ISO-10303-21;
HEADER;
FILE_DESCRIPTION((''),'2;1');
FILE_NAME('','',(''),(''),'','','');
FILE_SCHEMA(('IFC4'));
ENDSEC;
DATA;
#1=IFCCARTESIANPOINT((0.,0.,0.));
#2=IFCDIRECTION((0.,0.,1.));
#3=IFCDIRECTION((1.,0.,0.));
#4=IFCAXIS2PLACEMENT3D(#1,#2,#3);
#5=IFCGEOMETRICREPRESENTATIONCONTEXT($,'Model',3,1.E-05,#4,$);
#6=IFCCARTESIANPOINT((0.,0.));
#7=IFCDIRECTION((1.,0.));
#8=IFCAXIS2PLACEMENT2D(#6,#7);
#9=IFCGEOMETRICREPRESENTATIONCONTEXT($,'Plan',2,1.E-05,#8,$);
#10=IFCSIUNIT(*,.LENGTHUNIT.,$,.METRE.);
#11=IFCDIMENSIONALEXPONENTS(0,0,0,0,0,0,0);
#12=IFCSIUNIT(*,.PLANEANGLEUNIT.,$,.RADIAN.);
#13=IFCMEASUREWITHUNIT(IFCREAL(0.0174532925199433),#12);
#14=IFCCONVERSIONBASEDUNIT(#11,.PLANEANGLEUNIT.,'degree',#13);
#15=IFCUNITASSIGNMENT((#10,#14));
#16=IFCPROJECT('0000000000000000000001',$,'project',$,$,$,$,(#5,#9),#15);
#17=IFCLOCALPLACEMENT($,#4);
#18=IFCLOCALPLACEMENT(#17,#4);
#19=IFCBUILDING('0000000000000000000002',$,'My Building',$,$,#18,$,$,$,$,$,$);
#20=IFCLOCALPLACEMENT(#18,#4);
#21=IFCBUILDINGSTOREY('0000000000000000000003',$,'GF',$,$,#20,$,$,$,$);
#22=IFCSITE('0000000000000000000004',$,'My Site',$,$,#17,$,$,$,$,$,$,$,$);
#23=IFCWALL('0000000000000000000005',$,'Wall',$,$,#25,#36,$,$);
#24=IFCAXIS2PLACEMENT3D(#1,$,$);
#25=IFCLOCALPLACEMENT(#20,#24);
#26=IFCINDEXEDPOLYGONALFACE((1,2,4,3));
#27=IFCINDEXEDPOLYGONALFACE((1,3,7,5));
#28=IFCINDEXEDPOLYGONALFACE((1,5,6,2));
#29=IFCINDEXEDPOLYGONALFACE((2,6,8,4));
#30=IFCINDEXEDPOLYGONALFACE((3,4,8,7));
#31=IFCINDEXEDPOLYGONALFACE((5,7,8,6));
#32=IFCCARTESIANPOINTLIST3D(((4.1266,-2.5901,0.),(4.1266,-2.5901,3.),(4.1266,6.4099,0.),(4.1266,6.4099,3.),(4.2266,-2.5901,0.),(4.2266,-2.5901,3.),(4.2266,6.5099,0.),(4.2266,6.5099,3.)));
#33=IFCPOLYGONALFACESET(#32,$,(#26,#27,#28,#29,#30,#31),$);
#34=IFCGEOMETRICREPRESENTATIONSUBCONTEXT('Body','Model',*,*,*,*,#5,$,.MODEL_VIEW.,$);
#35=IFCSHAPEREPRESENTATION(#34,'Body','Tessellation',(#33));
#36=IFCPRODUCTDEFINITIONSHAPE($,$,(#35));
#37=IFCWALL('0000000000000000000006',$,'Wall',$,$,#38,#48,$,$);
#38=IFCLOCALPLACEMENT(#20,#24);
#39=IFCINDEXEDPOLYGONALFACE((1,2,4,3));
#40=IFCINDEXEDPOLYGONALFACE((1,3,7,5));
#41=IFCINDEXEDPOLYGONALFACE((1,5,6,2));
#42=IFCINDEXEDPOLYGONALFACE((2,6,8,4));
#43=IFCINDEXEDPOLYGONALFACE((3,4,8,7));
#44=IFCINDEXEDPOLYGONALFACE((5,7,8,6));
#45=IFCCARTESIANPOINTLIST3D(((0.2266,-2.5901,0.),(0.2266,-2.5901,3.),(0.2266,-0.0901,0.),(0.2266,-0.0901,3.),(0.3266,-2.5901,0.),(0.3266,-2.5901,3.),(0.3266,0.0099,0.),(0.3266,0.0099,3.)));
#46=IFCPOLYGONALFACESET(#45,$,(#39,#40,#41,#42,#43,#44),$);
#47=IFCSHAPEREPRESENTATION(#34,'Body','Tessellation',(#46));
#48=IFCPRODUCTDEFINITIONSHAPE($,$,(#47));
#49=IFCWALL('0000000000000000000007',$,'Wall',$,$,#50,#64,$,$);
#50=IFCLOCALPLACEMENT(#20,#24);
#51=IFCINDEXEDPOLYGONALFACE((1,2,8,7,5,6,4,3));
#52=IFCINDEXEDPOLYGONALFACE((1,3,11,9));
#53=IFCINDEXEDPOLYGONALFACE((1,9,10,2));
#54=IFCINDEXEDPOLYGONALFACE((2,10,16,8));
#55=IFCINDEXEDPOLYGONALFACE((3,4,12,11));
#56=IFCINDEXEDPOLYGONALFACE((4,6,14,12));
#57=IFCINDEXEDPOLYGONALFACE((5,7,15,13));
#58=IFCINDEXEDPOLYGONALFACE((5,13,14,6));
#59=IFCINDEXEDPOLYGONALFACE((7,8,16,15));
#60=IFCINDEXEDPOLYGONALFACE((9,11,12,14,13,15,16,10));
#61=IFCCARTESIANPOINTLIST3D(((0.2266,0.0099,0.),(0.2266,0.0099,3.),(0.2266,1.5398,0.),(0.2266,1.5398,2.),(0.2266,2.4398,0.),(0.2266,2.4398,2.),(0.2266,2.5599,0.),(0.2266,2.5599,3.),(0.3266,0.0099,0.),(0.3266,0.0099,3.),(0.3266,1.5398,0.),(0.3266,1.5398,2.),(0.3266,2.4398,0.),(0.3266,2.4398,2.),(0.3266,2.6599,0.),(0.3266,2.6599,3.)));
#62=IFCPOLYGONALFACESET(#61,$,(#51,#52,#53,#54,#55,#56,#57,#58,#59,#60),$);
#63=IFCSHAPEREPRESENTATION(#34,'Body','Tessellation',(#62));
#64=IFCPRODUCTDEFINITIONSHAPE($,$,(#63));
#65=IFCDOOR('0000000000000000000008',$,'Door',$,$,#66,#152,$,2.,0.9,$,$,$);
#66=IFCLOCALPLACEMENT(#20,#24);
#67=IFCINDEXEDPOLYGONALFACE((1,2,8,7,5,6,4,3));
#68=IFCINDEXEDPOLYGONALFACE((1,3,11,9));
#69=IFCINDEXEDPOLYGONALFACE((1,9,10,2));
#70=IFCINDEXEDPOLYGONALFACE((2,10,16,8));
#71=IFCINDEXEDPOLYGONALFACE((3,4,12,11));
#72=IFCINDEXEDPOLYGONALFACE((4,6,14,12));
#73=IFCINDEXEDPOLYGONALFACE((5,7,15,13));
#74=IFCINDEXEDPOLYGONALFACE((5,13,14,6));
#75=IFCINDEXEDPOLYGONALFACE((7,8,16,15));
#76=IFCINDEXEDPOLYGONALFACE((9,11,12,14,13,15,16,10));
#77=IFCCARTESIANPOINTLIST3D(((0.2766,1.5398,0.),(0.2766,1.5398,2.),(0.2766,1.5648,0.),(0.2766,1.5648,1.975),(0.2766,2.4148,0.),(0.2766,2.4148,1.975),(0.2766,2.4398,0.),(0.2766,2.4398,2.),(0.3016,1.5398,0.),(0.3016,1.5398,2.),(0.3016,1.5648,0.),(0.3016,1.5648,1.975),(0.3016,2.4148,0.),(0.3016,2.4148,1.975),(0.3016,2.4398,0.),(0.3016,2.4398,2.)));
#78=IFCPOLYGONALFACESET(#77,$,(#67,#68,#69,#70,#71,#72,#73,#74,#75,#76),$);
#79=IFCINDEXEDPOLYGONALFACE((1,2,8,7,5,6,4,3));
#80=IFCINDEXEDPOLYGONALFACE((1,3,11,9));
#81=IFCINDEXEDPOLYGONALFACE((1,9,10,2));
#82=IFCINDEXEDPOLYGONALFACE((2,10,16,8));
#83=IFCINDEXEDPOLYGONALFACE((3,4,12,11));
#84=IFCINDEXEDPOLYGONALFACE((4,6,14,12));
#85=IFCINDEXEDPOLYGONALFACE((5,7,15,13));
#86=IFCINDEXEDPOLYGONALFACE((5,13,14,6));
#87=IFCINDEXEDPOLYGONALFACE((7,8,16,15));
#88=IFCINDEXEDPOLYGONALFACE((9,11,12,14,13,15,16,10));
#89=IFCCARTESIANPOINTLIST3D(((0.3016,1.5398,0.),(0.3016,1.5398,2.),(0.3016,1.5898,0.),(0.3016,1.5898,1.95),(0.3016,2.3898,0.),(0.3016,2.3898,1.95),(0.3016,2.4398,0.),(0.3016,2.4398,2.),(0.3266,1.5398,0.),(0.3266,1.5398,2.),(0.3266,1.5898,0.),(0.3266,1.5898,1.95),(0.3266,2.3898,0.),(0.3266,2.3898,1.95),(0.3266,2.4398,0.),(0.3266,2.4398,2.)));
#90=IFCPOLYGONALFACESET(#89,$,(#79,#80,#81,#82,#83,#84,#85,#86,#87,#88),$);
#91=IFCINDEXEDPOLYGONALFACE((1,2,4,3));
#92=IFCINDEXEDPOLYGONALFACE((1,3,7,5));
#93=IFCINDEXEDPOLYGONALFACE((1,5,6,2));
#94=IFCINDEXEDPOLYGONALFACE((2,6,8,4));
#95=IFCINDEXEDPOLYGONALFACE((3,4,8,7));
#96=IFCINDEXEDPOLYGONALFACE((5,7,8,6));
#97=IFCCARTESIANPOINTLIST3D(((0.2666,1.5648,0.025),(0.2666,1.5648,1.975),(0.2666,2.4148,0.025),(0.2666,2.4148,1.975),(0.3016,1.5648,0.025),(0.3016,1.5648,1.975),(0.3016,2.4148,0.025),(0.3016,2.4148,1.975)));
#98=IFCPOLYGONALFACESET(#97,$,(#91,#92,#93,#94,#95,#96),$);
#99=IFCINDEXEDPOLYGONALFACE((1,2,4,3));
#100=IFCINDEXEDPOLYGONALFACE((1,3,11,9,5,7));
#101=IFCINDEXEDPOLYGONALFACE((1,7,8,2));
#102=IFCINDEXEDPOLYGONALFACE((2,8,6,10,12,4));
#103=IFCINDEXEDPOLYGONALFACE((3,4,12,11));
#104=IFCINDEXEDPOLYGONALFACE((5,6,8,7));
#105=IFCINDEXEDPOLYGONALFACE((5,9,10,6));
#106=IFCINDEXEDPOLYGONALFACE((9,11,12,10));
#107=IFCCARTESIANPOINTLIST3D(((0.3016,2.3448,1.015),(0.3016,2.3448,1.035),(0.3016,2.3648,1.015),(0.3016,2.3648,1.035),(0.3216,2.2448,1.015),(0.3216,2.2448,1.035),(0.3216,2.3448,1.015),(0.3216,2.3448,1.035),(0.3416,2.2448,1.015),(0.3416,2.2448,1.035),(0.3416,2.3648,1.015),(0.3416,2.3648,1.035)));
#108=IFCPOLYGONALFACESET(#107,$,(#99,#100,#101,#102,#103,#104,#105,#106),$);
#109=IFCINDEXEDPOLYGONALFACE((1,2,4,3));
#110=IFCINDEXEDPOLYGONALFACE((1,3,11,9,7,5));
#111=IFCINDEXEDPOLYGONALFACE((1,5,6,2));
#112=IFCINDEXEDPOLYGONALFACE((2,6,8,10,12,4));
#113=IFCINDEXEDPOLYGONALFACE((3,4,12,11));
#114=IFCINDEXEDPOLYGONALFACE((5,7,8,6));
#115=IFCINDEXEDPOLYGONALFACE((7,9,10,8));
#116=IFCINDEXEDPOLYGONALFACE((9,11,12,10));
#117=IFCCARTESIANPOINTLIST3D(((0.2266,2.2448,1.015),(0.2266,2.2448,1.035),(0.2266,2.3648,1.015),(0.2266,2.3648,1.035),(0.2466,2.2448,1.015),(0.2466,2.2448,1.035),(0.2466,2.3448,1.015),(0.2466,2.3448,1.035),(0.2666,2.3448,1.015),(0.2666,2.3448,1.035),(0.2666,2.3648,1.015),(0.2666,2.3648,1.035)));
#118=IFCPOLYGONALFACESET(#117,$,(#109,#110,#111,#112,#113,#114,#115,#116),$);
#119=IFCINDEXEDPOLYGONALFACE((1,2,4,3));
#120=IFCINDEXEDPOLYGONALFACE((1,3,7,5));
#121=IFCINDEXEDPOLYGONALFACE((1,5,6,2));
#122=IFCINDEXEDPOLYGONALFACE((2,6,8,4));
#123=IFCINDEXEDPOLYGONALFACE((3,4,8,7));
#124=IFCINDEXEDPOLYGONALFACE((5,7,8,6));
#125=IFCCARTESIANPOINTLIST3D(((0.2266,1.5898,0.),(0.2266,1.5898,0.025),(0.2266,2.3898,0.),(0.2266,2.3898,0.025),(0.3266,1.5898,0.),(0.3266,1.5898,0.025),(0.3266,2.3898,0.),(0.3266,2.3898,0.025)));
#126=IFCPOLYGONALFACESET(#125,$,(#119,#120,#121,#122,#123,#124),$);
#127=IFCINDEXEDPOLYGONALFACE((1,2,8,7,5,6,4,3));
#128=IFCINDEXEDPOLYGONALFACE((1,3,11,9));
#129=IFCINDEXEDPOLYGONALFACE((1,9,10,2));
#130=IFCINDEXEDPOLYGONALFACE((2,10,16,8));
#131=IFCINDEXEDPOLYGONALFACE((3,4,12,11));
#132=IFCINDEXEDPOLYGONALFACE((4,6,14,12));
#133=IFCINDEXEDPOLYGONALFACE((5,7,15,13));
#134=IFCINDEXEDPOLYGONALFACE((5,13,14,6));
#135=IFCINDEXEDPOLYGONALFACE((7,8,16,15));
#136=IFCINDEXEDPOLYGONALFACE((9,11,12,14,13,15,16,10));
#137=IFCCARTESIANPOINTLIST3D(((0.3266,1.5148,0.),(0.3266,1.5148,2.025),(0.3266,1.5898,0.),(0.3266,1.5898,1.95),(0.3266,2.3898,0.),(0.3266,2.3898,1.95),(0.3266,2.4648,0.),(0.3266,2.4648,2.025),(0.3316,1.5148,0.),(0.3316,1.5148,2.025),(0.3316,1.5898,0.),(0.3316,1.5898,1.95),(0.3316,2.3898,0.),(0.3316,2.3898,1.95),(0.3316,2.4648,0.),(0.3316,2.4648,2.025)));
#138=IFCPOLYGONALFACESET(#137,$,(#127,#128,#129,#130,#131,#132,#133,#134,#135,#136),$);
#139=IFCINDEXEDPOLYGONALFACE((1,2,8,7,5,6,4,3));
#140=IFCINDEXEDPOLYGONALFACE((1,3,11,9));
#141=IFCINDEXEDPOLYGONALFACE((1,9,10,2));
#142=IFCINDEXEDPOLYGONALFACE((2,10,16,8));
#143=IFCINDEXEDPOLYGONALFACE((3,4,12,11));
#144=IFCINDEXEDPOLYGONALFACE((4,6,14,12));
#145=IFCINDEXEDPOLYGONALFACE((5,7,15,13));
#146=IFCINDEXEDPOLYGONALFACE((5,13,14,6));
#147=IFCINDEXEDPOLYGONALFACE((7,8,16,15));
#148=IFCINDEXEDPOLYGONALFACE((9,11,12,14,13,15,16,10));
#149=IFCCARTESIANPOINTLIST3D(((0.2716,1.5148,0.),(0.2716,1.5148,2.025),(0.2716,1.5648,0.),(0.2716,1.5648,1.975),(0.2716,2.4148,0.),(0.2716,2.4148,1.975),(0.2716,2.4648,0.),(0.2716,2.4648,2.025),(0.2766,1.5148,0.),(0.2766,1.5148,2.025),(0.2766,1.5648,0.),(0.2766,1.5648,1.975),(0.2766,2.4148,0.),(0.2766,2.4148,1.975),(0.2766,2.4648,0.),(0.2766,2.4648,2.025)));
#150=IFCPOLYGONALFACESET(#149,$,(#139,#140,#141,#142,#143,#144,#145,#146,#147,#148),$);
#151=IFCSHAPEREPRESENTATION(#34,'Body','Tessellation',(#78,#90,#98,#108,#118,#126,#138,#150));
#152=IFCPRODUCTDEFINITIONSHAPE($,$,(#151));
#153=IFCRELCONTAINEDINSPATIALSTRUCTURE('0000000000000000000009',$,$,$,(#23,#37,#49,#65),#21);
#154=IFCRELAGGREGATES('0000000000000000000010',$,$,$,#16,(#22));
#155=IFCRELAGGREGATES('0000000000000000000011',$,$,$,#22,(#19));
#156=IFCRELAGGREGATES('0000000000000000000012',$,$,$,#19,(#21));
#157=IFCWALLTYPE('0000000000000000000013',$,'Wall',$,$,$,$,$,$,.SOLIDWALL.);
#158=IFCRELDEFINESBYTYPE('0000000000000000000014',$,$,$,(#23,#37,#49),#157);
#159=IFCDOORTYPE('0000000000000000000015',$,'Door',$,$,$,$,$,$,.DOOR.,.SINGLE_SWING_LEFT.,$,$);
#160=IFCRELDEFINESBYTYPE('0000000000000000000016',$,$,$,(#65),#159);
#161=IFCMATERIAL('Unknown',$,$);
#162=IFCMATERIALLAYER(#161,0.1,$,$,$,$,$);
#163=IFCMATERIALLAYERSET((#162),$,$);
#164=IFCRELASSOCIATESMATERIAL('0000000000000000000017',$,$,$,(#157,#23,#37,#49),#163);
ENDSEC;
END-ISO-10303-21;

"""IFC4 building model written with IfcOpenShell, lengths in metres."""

from ifc_helpers import new_model, entity, si_unit, converted_unit, frame, origin_with_axes, origin_2d_with_axis, place, context, subcontext, project, spatial, line, indexed_curve, outline, extrude, shape, source, transform, mapped, material, layer, layer_set, layer_usage, type_object, type_shapes, element, fill, save


model = new_model("IFC4")

# Units and contexts
model_context = context("Model", 3, precision=1e-05, world=origin_with_axes())
plan_context = context("Plan", 2, precision=1e-05, world=origin_2d_with_axis())
body_context_1 = subcontext(model_context, "Body", "Model", "MODEL_VIEW")
body_context_2 = subcontext(plan_context, "Body", "Plan", "PLAN_VIEW")
ifc_project = project(units=[si_unit("LENGTHUNIT", "METRE"), converted_unit("PLANEANGLEUNIT", "degree", entity("IfcReal", 0.0174532925199433), si_unit("PLANEANGLEUNIT", "RADIAN"), dimensions=[0, 0, 0, 0, 0, 0, 0])], contexts=[model_context, plan_context])

# Site, building, storey
site_placement = place(None, origin_with_axes())
site = spatial("IfcSite", under=ifc_project, at=site_placement, Name="My Site")
building_placement = place(site_placement, origin_with_axes())
building = spatial("IfcBuilding", under=site, at=building_placement, Name="My Building")
storey_placement = place(building_placement, origin_with_axes())
storey = spatial("IfcBuildingStorey", under=building, at=storey_placement, Name="GF")

# Shared definitions
ifc_material = material(Name="Unknown")

# Shared definitions
ifc_layer_1 = layer(ifc_material, 0.1)
ifc_layer_set_1 = layer_set([ifc_layer_1])
wall_type = type_object("IfcWallType", Name="Wall", PredefinedType="SOLIDWALL", material=ifc_layer_set_1)
shared_shape_1 = source(origin_with_axes(), body_context_1, "Body", "SweptSolid", [
    extrude(outline(indexed_curve([(0.0, 0.0), (0.9, 0.0), (0.9, 2.0), (0.0, 2.0)], segments=[line(1, 2, 3, 4, 1)])), frame((0.0, -0.6, 0.0), z_axis=(0.0, -1.0, 0.0), x_axis=(1.0, 0.0, 0.0)), (0.0, 0.0, -1.0), 1.2),
])
door_type = type_object("IfcDoorType", Name="Door", OperationType="SINGLE_SWING_LEFT", PredefinedType="DOOR")
shared_shape_2 = source(origin_with_axes(), body_context_1, "Body", "SweptSolid", [
    extrude(outline(indexed_curve([(0.0, 0.0), (0.0, 2.0), (0.9, 2.0), (0.9, 0.0), (0.875, 0.0), (0.875, 1.975), (0.025, 1.975), (0.025, 0.0)], segments=[line(1, 2, 3, 4, 5, 6, 7, 8, 1)])), frame((0.0, 0.025, 0.0), z_axis=(0.0, -1.0, 0.0), x_axis=(1.0, 0.0, 0.0)), (0.0, 0.0, -1.0), 0.025),
    extrude(outline(indexed_curve([(0.0, 0.0), (0.0, 2.0), (0.9, 2.0), (0.9, 0.0), (0.85, 0.0), (0.85, 1.95), (0.05, 1.95), (0.05, 0.0)], segments=[line(1, 2, 3, 4, 5, 6, 7, 8, 1)])), frame((0.0, 0.0, 0.0), z_axis=(0.0, -1.0, 0.0), x_axis=(1.0, 0.0, 0.0)), (0.0, 0.0, -1.0), 0.025),
    extrude(outline(indexed_curve([(0.0, 0.0), (0.85, 0.0), (0.85, 0.035), (0.0, 0.035)], segments=[line(1, 2, 3, 4, 1)])), frame((0.025, 0.025, 0.025), z_axis=(0.0, 0.0, 1.0), x_axis=(1.0, 0.0, 0.0)), (0.0, 0.0, 1.0), 1.95),
    extrude(outline(indexed_curve([(0.0, 0.0), (0.0, -0.04), (-0.12, -0.04), (-0.12, -0.02), (-0.02, -0.02), (-0.02, 0.0)], segments=[line(1, 2, 3, 4, 5, 6, 1)])), frame((0.825, 0.025, 1.015), z_axis=(0.0, 0.0, 1.0), x_axis=(1.0, 0.0, 0.0)), (0.0, 0.0, 1.0), 0.02),
    extrude(outline(indexed_curve([(0.0, 0.0), (0.0, 0.04), (-0.12, 0.04), (-0.12, 0.02), (-0.02, 0.02), (-0.02, 0.0)], segments=[line(1, 2, 3, 4, 5, 6, 1)])), frame((0.825, 0.06, 1.015), z_axis=(0.0, 0.0, 1.0), x_axis=(1.0, 0.0, 0.0)), (0.0, 0.0, 1.0), 0.02),
    extrude(outline(indexed_curve([(0.0, 0.0), (0.8, 0.0), (0.8, 0.1), (0.0, 0.1)], segments=[line(1, 2, 3, 4, 1)])), frame((0.05, 0.0, 0.0), z_axis=(0.0, 0.0, 1.0), x_axis=(1.0, 0.0, 0.0)), (0.0, 0.0, 1.0), 0.025),
    extrude(outline(indexed_curve([(0.0, 0.0), (0.0, 2.025), (0.95, 2.025), (0.95, 0.0), (0.875, 0.0), (0.875, 1.95), (0.075, 1.95), (0.075, 0.0)], segments=[line(1, 2, 3, 4, 5, 6, 7, 8, 1)])), frame((-0.025, -0.005, 0.0), z_axis=(0.0, -1.0, 0.0), x_axis=(1.0, 0.0, 0.0)), (0.0, 0.0, -1.0), 0.005),
    extrude(outline(indexed_curve([(0.0, 0.0), (0.0, 2.025), (0.95, 2.025), (0.95, 0.0), (0.9, 0.0), (0.9, 1.975), (0.05, 1.975), (0.05, 0.0)], segments=[line(1, 2, 3, 4, 5, 6, 7, 8, 1)])), frame((-0.025, 0.05, 0.0), z_axis=(0.0, -1.0, 0.0), x_axis=(1.0, 0.0, 0.0)), (0.0, 0.0, -1.0), 0.005),
])
shared_shape_3 = source(origin_with_axes(), body_context_2, "Body", "Curve2D", [
    entity("IfcIndexedPolyCurve", entity("IfcCartesianPointList2D", [[0.0, 0.0], [0.0, 0.05], [0.025, 0.05], [0.025, 0.025], [0.05, 0.025], [0.05, 0.0]]), [entity("IfcLineIndex", [1, 2, 3, 4, 5, 6, 1])]),
    entity("IfcIndexedPolyCurve", entity("IfcCartesianPointList2D", [[0.9, 0.0], [0.9, 0.05], [0.875, 0.05], [0.875, 0.025], [0.85, 0.025], [0.85, 0.0]]), [entity("IfcLineIndex", [1, 2, 3, 4, 5, 6, 1])]),
    entity("IfcTrimmedCurve", entity("IfcEllipse", entity("IfcAxis2Placement2D", entity("IfcCartesianPoint", [0.06, 0.05]), entity("IfcDirection", [1.0, 0.0])), 0.815, 0.85), [entity("IfcCartesianPoint", [0.875, 0.05])], [entity("IfcCartesianPoint", [0.06, 0.9])], True, "CARTESIAN"),
    entity("IfcIndexedPolyCurve", entity("IfcCartesianPointList2D", [[0.025, 0.05], [0.06, 0.05], [0.06, 0.9], [0.025, 0.9]]), [entity("IfcLineIndex", [1, 2, 3, 4, 1])]),
])
type_shapes(door_type, [shared_shape_2, shared_shape_3])

# Walls
ifc_layer_usage_1 = layer_usage(ifc_layer_set_1, "AXIS2", "POSITIVE", 0.0)
wall_1_placement = place(storey_placement, frame((4.2266, -2.5901, 0.0), z_axis=(0.0, 0.0, 1.0), x_axis=(0.0, 1.0, 0.0)))
element("IfcWall", 1, at=wall_1_placement, inside=storey, type_object=wall_type, material=ifc_layer_usage_1, Name="Wall", context=body_context_1, shape_type="SweptSolid", body=[
    extrude(outline(indexed_curve([(0.0, 0.0), (0.0, 0.1), (9.0, 0.1), (9.1, 0.0)], segments=[line(1, 2, 3, 4, 1)])), origin_with_axes(), (0.0, 0.0, 1.0), 3.0),
])
ifc_layer_usage_2 = layer_usage(ifc_layer_set_1, "AXIS2", "POSITIVE", 0.0)
wall_2_placement = place(storey_placement, frame((0.2266, -0.0901, 0.0), z_axis=(0.0, 0.0, 1.0), x_axis=(0.0, -1.0, 0.0)))
element("IfcWall", 2, at=wall_2_placement, inside=storey, type_object=wall_type, material=ifc_layer_usage_2, Name="Wall", context=body_context_1, shape_type="SweptSolid", body=[
    extrude(outline(indexed_curve([(0.0, 0.0), (-0.1, 0.1), (2.5, 0.1), (2.5, 0.0)], segments=[line(1, 2, 3, 4, 1)])), origin_with_axes(), (0.0, 0.0, 1.0), 3.0),
])

# Wall, opening, door
ifc_layer_usage_3 = layer_usage(ifc_layer_set_1, "AXIS2", "POSITIVE", 0.0)
wall_3_placement = place(storey_placement, frame((0.3266, 0.0099, 0.0), z_axis=(0.0, 0.0, 1.0), x_axis=(0.0, 1.0, 0.0)))
wall_3 = element("IfcWall", 3, at=wall_3_placement, inside=storey, type_object=wall_type, material=ifc_layer_usage_3, Name="Wall", context=body_context_1, shape_type="SweptSolid", body=[
    extrude(outline(indexed_curve([(0.0, 0.0), (0.0, 0.1), (2.55, 0.1), (2.65, 0.0)], segments=[line(1, 2, 3, 4, 1)])), origin_with_axes(), (0.0, 0.0, 1.0), 3.0),
])
opening_1_placement = place(wall_3_placement, frame((1.5299, 0.0, 0.0), z_axis=(0.0, 0.0, 1.0), x_axis=(1.0, 0.0, 0.0)))
opening_1 = element("IfcOpeningElement", 4, at=opening_1_placement, cuts=wall_3, PredefinedType="OPENING", context=body_context_1, shape_type="MappedRepresentation", body=[
    mapped(shared_shape_1, transform((0.0, 0.0, 0.0), x_axis=(1.0, 0.0, 0.0), y_axis=(0.0, 1.0, 0.0), z_axis=(0.0, 0.0, 1.0), scale=1.0)),
])
door_1_placement = place(opening_1_placement, frame((0.0, 0.0, 0.0), z_axis=(0.0, 0.0, 1.0), x_axis=(1.0, 0.0, 0.0)))
door_1 = element("IfcDoor", 5, at=door_1_placement, inside=storey, type_object=door_type, Name="Door", OverallHeight=2.0, OverallWidth=0.9, shapes=[
    shape(body_context_1, "Body", "MappedRepresentation", [mapped(shared_shape_2, transform((0.0, 0.0, 0.0), x_axis=(1.0, 0.0, 0.0), y_axis=(0.0, 1.0, 0.0), z_axis=(0.0, 0.0, 1.0), scale=1.0))]),
    shape(body_context_2, "Body", "MappedRepresentation", [mapped(shared_shape_3, transform((0.0, 0.0, 0.0), x_axis=(1.0, 0.0, 0.0), y_axis=(0.0, 1.0, 0.0), z_axis=(0.0, 0.0, 1.0), scale=1.0))]),
])
fill(opening_1, door_1)

save(model, "model.ifc")
